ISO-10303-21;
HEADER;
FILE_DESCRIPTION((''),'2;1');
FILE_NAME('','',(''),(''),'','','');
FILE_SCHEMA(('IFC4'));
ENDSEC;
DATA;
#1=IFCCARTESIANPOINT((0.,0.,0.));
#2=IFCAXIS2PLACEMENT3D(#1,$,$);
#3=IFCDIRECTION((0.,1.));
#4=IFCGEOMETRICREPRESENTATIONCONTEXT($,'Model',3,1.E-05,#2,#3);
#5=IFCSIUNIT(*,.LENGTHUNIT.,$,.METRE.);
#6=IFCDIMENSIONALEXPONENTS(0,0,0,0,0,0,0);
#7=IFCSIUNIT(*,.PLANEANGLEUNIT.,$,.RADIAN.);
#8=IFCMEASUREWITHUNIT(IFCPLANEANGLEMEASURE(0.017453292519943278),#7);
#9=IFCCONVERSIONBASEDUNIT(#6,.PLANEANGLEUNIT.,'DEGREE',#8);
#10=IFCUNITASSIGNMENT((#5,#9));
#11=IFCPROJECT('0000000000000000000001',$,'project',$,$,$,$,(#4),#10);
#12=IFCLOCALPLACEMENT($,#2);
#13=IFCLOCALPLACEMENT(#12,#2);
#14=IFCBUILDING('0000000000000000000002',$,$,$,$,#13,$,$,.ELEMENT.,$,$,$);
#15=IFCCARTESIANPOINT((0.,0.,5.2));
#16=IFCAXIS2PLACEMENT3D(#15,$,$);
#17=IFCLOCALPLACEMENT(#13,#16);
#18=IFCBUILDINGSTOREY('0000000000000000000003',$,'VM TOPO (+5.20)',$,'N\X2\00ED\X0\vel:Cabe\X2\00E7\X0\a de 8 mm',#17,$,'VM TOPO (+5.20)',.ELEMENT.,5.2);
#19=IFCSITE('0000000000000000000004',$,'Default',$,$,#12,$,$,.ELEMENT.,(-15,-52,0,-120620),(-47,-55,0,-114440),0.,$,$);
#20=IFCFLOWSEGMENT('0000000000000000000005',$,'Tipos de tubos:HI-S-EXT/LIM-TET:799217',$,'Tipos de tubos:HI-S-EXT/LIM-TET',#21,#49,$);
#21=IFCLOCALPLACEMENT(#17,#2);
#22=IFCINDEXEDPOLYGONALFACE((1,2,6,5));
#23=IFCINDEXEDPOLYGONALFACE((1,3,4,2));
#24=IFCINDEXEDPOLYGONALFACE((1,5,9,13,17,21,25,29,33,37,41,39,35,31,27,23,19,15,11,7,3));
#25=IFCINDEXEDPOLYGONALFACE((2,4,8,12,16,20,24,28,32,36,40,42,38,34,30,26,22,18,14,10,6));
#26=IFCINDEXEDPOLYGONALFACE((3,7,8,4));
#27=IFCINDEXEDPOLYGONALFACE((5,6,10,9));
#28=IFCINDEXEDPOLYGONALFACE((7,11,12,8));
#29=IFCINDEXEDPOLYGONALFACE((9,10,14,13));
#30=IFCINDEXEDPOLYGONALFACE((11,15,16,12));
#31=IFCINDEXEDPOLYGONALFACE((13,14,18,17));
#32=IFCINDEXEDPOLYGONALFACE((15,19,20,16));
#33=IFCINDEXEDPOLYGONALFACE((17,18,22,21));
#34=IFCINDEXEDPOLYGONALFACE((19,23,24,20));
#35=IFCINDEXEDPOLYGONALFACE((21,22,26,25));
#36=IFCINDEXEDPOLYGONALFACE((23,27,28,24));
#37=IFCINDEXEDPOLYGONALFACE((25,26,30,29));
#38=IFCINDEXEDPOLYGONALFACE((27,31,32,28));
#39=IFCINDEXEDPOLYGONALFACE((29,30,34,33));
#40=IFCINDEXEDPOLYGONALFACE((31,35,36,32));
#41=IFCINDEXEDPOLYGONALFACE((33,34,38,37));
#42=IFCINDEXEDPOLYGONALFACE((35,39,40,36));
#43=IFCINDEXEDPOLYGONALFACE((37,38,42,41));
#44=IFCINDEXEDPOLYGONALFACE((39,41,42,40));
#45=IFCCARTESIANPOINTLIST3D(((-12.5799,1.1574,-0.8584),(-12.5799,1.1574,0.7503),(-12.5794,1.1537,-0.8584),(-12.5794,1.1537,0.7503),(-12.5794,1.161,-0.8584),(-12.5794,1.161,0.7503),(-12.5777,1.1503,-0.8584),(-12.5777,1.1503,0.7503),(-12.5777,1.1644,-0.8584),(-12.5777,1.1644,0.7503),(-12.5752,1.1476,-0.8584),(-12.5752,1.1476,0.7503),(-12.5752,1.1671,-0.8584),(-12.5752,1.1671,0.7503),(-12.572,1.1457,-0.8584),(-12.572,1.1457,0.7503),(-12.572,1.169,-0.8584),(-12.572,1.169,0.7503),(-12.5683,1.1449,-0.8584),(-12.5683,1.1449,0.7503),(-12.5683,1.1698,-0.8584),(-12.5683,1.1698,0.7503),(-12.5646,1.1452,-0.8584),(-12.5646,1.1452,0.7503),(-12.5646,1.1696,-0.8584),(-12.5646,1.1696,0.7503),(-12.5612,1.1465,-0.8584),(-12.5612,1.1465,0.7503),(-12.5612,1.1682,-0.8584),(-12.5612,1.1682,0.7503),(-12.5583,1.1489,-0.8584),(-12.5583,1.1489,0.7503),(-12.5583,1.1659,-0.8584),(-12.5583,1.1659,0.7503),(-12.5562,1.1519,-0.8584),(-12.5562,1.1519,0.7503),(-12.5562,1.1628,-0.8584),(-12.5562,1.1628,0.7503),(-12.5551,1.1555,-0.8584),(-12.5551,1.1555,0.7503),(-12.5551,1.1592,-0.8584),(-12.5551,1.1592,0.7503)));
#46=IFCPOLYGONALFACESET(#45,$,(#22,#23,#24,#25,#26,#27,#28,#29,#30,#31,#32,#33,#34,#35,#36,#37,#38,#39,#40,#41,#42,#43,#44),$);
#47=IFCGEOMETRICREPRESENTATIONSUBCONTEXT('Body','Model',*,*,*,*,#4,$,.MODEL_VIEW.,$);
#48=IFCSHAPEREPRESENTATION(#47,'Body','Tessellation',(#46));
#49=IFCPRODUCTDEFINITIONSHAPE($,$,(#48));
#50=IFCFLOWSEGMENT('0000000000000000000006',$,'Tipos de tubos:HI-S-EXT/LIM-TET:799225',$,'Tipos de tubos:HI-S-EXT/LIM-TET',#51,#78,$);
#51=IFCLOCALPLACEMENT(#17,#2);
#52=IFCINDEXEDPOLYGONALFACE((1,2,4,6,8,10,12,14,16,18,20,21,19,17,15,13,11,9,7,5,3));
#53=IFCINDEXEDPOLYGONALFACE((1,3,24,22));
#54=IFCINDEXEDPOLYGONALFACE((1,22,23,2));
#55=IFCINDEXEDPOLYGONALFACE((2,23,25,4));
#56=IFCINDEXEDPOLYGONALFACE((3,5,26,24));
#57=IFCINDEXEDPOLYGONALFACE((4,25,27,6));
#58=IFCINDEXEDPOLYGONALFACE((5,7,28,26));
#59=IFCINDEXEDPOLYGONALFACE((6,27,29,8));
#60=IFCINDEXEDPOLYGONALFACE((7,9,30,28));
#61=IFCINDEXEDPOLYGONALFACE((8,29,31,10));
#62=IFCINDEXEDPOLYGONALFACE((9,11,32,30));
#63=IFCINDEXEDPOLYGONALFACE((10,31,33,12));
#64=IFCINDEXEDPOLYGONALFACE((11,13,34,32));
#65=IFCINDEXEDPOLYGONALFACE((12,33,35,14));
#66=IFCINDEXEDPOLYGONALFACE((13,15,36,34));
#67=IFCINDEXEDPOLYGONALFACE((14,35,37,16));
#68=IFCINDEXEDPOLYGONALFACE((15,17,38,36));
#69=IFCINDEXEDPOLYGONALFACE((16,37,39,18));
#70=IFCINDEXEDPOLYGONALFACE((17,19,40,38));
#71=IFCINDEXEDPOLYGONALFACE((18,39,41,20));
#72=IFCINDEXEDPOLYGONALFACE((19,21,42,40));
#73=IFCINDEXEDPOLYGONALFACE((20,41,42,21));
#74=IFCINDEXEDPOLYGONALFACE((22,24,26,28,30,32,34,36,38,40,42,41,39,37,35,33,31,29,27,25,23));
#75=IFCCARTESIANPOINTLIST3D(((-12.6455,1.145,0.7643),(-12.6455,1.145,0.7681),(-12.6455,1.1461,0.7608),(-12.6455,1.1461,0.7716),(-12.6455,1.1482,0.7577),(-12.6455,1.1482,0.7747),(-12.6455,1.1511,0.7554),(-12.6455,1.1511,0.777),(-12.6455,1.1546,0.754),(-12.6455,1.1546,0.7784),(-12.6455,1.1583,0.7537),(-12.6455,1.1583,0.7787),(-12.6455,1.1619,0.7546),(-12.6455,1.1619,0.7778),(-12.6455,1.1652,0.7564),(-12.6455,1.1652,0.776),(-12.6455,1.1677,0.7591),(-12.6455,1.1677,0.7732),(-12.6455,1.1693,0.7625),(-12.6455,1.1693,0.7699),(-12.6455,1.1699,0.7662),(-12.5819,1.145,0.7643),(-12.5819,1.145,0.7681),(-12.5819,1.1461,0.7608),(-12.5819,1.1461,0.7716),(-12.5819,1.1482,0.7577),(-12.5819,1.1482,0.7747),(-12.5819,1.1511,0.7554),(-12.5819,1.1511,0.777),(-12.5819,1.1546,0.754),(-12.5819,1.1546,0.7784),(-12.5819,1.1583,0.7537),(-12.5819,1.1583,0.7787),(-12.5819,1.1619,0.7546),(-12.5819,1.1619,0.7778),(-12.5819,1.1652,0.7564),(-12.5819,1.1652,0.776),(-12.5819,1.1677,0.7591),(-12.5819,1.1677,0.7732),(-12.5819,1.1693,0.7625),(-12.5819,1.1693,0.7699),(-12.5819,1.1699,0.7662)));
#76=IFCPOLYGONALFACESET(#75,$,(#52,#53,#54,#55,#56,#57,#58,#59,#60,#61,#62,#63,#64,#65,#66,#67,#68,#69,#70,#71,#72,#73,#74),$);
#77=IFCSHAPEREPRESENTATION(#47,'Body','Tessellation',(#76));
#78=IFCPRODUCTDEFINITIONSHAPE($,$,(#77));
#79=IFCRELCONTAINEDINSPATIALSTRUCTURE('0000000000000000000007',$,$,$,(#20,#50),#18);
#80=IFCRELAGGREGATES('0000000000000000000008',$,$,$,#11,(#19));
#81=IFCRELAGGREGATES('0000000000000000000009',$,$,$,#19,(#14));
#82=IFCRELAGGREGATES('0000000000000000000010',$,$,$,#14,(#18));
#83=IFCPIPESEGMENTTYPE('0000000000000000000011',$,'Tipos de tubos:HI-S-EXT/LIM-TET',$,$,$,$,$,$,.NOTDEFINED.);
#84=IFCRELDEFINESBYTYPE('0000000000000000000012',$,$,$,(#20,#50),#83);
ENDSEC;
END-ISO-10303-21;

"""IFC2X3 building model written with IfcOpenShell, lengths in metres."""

from ifc_helpers import new_model, entity, si_unit, converted_unit, direction, frame, origin, origin_2d_with_axis, place, context, subcontext, project, spatial, circle, extrude, type_object, element, save


model = new_model("IFC2X3")

# Units and contexts
model_context = context("Model", 3, precision=1e-05, world=origin(), true_north=direction((0.0, 1.0)))
body_context = subcontext(model_context, "Body", "Model", "MODEL_VIEW")
ifc_project = project(units=[si_unit("LENGTHUNIT", "METRE"), converted_unit("PLANEANGLEUNIT", "DEGREE", entity("IfcPlaneAngleMeasure", 0.017453292519943278), si_unit("PLANEANGLEUNIT", "RADIAN"), dimensions=[0, 0, 0, 0, 0, 0, 0])], contexts=[model_context])

# Site, building, storey
site_placement = place(None, origin())
site = spatial("IfcSite", under=ifc_project, at=site_placement, Name="Default", CompositionType="ELEMENT", RefLatitude=(-15, -52, 0, -120620), RefLongitude=(-47, -55, 0, -114440), RefElevation=0.0)
building_placement = place(site_placement, origin())
building = spatial("IfcBuilding", under=site, at=building_placement, CompositionType="ELEMENT")
storey_placement = place(building_placement, frame((0.0, 0.0, 5.2)))
storey = spatial("IfcBuildingStorey", under=building, at=storey_placement, Name="VM TOPO (+5.20)", ObjectType="Nível:Cabeça de 8 mm", LongName="VM TOPO (+5.20)", CompositionType="ELEMENT", Elevation=5.2)

# Flow segments
pipe_segment_type_1 = type_object("IfcPipeSegmentType", Name="Tipos de tubos:HI-S-EXT/LIM-TET", PredefinedType="NOTDEFINED")
flow_segment_1_placement = place(storey_placement, origin())
element("IfcFlowSegment", 1, at=flow_segment_1_placement, inside=storey, type_object=pipe_segment_type_1, Name="Tipos de tubos:HI-S-EXT/LIM-TET:799217", ObjectType="Tipos de tubos:HI-S-EXT/LIM-TET", context=body_context, shape_type="SweptSolid", body=[
    extrude(circle(Radius=0.0125, at=origin_2d_with_axis()), frame((-12.5674, 1.1574, -0.8584), z_axis=(0.0, 0.0, 1.0), x_axis=(-1.0, 0.0, 0.0)), (0.0, 0.0, 1.0), 1.6087),
])
flow_segment_2_placement = place(storey_placement, origin())
element("IfcFlowSegment", 2, at=flow_segment_2_placement, inside=storey, type_object=pipe_segment_type_1, Name="Tipos de tubos:HI-S-EXT/LIM-TET:799225", ObjectType="Tipos de tubos:HI-S-EXT/LIM-TET", context=body_context, shape_type="SweptSolid", body=[
    extrude(circle(Radius=0.0125, at=origin_2d_with_axis()), frame((-12.6455, 1.1574, 0.7662), z_axis=(1.0, 0.0, 0.0), x_axis=(0.0, 1.0, 0.0)), (0.0, 0.0, 1.0), 0.0636),
])

save(model, "model.ifc")
